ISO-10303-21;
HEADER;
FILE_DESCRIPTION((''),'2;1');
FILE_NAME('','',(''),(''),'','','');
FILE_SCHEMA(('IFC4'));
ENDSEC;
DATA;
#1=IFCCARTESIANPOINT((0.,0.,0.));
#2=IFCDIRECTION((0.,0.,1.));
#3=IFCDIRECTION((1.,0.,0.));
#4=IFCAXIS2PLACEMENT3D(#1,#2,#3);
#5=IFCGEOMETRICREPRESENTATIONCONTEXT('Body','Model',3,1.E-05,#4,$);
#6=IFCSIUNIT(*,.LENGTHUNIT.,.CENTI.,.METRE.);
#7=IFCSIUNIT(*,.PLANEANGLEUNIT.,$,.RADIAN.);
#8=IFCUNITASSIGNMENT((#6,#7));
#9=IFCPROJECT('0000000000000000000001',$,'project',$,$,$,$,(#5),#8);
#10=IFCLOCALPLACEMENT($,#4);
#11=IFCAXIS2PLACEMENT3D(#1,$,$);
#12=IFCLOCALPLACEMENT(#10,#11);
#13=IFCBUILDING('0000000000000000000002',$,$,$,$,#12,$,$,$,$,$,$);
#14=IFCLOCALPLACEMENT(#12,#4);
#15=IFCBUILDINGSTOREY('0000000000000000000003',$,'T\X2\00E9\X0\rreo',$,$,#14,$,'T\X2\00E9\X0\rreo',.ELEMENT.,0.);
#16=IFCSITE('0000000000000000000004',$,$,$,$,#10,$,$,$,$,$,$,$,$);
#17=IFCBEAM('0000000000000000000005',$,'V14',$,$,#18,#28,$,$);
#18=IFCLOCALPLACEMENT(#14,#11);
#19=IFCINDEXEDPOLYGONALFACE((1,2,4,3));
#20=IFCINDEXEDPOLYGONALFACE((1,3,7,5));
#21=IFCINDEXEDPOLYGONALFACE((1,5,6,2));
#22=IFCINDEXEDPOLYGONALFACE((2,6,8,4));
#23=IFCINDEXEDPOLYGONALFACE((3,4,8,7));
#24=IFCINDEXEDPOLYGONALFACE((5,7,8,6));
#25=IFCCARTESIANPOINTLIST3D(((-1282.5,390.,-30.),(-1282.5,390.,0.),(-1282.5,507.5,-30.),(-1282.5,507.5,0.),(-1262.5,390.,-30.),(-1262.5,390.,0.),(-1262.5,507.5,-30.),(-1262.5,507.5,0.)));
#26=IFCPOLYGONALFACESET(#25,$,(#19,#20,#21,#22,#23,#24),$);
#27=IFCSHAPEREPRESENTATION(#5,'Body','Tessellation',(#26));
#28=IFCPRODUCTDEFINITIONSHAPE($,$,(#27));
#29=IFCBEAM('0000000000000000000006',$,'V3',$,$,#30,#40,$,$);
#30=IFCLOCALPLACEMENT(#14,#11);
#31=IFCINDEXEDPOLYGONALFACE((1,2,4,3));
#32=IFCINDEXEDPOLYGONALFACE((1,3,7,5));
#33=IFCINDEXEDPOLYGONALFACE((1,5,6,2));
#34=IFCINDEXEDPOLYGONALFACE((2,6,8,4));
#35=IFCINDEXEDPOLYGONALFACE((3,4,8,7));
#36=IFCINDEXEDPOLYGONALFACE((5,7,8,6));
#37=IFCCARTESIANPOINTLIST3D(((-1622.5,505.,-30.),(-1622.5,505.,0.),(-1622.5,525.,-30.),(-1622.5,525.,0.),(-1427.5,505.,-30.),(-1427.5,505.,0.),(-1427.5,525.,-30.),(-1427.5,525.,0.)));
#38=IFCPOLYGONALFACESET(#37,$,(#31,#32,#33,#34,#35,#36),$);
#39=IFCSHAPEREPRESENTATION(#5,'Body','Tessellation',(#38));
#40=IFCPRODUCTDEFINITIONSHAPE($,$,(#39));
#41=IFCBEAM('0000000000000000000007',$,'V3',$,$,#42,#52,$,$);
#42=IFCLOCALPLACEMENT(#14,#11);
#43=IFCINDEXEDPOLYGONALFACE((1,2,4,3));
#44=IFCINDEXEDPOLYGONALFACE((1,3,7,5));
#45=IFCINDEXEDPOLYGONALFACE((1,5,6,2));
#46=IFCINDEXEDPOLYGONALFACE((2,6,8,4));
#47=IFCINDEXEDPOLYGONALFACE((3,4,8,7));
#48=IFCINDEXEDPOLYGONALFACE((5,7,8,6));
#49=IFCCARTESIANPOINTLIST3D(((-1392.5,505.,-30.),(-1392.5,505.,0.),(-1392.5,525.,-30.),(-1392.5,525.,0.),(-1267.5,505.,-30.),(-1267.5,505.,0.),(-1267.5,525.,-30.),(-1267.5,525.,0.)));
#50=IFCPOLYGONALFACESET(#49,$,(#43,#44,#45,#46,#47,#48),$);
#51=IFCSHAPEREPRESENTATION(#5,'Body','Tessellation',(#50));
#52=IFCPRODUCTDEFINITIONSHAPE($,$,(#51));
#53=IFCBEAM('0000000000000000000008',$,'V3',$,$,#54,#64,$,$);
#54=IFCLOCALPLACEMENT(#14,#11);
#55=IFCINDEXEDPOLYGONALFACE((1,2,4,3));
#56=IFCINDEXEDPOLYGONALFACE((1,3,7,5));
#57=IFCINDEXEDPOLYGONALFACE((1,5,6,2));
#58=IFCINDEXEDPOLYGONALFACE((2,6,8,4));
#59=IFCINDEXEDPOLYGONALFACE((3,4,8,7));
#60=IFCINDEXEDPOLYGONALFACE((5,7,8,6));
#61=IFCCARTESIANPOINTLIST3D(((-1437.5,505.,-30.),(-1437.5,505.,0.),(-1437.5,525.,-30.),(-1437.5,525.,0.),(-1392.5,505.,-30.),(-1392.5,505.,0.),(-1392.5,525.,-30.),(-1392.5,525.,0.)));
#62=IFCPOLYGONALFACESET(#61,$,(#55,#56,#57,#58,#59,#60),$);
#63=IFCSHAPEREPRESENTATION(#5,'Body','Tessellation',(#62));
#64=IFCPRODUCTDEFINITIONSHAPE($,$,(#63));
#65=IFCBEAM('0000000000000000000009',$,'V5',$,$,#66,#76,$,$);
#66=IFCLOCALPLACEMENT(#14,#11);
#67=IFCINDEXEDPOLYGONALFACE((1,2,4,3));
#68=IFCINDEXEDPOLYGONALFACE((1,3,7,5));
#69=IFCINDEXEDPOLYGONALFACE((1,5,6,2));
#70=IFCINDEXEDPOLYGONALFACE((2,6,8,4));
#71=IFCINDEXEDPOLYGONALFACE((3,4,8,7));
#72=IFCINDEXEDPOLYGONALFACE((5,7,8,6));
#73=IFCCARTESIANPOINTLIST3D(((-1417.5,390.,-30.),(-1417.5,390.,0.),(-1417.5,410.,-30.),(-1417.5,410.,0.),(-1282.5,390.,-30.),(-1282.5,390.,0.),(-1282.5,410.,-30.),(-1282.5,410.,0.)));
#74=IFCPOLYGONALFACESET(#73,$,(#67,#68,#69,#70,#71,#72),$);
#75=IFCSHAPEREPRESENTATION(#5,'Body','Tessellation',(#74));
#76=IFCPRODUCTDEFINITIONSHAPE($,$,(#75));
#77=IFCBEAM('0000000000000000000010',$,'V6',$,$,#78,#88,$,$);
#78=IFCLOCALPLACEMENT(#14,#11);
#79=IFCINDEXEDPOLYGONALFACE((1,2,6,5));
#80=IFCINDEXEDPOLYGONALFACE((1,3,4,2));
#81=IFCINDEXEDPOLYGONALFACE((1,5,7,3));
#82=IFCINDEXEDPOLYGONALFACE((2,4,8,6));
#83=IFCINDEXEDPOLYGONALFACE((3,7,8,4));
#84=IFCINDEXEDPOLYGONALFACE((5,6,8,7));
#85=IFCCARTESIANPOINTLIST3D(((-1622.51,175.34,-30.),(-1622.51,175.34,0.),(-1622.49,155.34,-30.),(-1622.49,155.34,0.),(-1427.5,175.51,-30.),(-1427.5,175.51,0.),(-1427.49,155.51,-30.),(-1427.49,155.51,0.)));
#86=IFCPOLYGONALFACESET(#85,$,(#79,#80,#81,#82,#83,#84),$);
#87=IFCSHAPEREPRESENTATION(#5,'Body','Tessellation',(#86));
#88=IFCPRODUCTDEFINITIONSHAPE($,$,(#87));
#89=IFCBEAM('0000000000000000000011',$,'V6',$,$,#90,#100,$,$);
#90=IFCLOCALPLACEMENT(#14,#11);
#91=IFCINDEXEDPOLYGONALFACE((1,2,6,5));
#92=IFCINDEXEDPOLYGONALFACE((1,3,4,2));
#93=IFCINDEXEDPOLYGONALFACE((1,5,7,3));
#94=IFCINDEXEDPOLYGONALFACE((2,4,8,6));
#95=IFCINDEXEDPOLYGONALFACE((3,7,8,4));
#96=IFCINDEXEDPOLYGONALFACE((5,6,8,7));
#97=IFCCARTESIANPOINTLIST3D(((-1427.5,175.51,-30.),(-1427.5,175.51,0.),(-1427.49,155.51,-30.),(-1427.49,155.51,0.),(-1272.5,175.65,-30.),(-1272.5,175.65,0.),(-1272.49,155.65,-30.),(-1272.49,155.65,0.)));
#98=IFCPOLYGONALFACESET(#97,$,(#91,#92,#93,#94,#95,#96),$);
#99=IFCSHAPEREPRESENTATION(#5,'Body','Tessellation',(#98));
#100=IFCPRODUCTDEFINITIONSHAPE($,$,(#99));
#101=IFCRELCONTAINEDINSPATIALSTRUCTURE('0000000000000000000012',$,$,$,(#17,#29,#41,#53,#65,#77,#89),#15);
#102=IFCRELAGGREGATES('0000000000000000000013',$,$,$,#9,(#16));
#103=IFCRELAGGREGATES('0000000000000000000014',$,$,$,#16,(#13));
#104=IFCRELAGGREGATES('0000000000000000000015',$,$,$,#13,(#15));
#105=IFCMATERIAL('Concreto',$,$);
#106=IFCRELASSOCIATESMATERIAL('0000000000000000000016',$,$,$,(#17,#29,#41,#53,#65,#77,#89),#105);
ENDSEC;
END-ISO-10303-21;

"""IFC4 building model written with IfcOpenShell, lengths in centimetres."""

from ifc_helpers import new_model, si_unit, frame, origin, origin_with_axes, origin_2d_with_axis, place, context, project, spatial, rectangle, extrude, material, element, save


model = new_model("IFC4")

# Units and contexts
model_context = context("Model", 3, precision=1e-05, world=origin_with_axes(), identifier="Body")
ifc_project = project(units=[si_unit("LENGTHUNIT", "METRE", prefix="CENTI"), si_unit("PLANEANGLEUNIT", "RADIAN")], contexts=[model_context])

# Site, building, storey
site_placement = place(None, origin_with_axes())
site = spatial("IfcSite", under=ifc_project, at=site_placement)
building_placement = place(site_placement, origin())
building = spatial("IfcBuilding", under=site, at=building_placement)
storey_placement = place(building_placement, origin_with_axes())
storey = spatial("IfcBuildingStorey", under=building, at=storey_placement, Name="Térreo", LongName="Térreo", CompositionType="ELEMENT", Elevation=0.0)

# Shared definitions
ifc_material = material(Name="Concreto")

# Beams
beam_1_placement = place(storey_placement, frame((-1272.5, 448.75, 0.0), z_axis=(0.0, 0.0, 1.0), x_axis=(1.0, 0.0, 0.0)))
element("IfcBeam", 1, at=beam_1_placement, inside=storey, material=ifc_material, Name="V14", context=model_context, shape_type="SolidModel", body=[
    extrude(rectangle(XDim=20.0, YDim=30.0, at=origin_2d_with_axis()), frame((0.0, -58.75, -15.0), z_axis=(0.0, 1.0, 0.0), x_axis=(-1.0, 0.0, 0.0)), (0.0, 0.0, 1.0), 117.5),
])
beam_2_placement = place(storey_placement, frame((-1525.0, 515.0, 0.0), z_axis=(0.0, 0.0, 1.0), x_axis=(1.0, 0.0, 0.0)))
element("IfcBeam", 2, at=beam_2_placement, inside=storey, material=ifc_material, Name="V3", context=model_context, shape_type="SolidModel", body=[
    extrude(rectangle(XDim=20.0, YDim=30.0, at=origin_2d_with_axis()), frame((-97.5, 0.0, -15.0), z_axis=(1.0, 0.0, 0.0), x_axis=(0.0, -1.0, 0.0)), (0.0, 0.0, 1.0), 195.0),
])
beam_3_placement = place(storey_placement, frame((-1330.0, 515.0, 0.0), z_axis=(0.0, 0.0, 1.0), x_axis=(1.0, 0.0, 0.0)))
element("IfcBeam", 3, at=beam_3_placement, inside=storey, material=ifc_material, Name="V3", context=model_context, shape_type="SolidModel", body=[
    extrude(rectangle(XDim=20.0, YDim=30.0, at=origin_2d_with_axis()), frame((-62.5, 0.0, -15.0), z_axis=(1.0, 0.0, 0.0), x_axis=(0.0, -1.0, 0.0)), (0.0, 0.0, 1.0), 125.0),
])
beam_4_placement = place(storey_placement, frame((-1415.0, 515.0, 0.0), z_axis=(0.0, 0.0, 1.0), x_axis=(1.0, 0.0, 0.0)))
element("IfcBeam", 4, at=beam_4_placement, inside=storey, material=ifc_material, Name="V3", context=model_context, shape_type="SolidModel", body=[
    extrude(rectangle(XDim=20.0, YDim=30.0, at=origin_2d_with_axis()), frame((-22.5, 0.0, -15.0), z_axis=(1.0, 0.0, 0.0), x_axis=(0.0, -1.0, 0.0)), (0.0, 0.0, 1.0), 45.0),
])
beam_5_placement = place(storey_placement, frame((-1350.0, 400.0, 0.0), z_axis=(0.0, 0.0, 1.0), x_axis=(1.0, 0.0, 0.0)))
element("IfcBeam", 5, at=beam_5_placement, inside=storey, material=ifc_material, Name="V5", context=model_context, shape_type="SolidModel", body=[
    extrude(rectangle(XDim=20.0, YDim=30.0, at=origin_2d_with_axis()), frame((-67.5, 0.0, -15.0), z_axis=(1.0, 0.0, 0.0), x_axis=(0.0, -1.0, 0.0)), (0.0, 0.0, 1.0), 135.0),
])
beam_6_placement = place(storey_placement, frame((-1525.0, 165.42, 0.0), z_axis=(0.0, 0.0, 1.0), x_axis=(1.0, 0.0, 0.0)))
element("IfcBeam", 6, at=beam_6_placement, inside=storey, material=ifc_material, Name="V6", context=model_context, shape_type="SolidModel", body=[
    extrude(rectangle(XDim=20.0, YDim=30.0, at=origin_2d_with_axis()), frame((-97.5, -0.08, -15.0), z_axis=(1.0, 0.000857, 0.0), x_axis=(0.000857, -1.0, 0.0)), (0.0, 0.0, 1.0), 195.0),
])
beam_7_placement = place(storey_placement, frame((-1350.0, 165.58, 0.0), z_axis=(0.0, 0.0, 1.0), x_axis=(1.0, 0.0, 0.0)))
element("IfcBeam", 7, at=beam_7_placement, inside=storey, material=ifc_material, Name="V6", context=model_context, shape_type="SolidModel", body=[
    extrude(rectangle(XDim=20.0, YDim=30.0, at=origin_2d_with_axis()), frame((-77.5, -0.07, -15.0), z_axis=(1.0, 0.000857, 0.0), x_axis=(0.000857, -1.0, 0.0)), (0.0, 0.0, 1.0), 155.0),
])

save(model, "model.ifc")
